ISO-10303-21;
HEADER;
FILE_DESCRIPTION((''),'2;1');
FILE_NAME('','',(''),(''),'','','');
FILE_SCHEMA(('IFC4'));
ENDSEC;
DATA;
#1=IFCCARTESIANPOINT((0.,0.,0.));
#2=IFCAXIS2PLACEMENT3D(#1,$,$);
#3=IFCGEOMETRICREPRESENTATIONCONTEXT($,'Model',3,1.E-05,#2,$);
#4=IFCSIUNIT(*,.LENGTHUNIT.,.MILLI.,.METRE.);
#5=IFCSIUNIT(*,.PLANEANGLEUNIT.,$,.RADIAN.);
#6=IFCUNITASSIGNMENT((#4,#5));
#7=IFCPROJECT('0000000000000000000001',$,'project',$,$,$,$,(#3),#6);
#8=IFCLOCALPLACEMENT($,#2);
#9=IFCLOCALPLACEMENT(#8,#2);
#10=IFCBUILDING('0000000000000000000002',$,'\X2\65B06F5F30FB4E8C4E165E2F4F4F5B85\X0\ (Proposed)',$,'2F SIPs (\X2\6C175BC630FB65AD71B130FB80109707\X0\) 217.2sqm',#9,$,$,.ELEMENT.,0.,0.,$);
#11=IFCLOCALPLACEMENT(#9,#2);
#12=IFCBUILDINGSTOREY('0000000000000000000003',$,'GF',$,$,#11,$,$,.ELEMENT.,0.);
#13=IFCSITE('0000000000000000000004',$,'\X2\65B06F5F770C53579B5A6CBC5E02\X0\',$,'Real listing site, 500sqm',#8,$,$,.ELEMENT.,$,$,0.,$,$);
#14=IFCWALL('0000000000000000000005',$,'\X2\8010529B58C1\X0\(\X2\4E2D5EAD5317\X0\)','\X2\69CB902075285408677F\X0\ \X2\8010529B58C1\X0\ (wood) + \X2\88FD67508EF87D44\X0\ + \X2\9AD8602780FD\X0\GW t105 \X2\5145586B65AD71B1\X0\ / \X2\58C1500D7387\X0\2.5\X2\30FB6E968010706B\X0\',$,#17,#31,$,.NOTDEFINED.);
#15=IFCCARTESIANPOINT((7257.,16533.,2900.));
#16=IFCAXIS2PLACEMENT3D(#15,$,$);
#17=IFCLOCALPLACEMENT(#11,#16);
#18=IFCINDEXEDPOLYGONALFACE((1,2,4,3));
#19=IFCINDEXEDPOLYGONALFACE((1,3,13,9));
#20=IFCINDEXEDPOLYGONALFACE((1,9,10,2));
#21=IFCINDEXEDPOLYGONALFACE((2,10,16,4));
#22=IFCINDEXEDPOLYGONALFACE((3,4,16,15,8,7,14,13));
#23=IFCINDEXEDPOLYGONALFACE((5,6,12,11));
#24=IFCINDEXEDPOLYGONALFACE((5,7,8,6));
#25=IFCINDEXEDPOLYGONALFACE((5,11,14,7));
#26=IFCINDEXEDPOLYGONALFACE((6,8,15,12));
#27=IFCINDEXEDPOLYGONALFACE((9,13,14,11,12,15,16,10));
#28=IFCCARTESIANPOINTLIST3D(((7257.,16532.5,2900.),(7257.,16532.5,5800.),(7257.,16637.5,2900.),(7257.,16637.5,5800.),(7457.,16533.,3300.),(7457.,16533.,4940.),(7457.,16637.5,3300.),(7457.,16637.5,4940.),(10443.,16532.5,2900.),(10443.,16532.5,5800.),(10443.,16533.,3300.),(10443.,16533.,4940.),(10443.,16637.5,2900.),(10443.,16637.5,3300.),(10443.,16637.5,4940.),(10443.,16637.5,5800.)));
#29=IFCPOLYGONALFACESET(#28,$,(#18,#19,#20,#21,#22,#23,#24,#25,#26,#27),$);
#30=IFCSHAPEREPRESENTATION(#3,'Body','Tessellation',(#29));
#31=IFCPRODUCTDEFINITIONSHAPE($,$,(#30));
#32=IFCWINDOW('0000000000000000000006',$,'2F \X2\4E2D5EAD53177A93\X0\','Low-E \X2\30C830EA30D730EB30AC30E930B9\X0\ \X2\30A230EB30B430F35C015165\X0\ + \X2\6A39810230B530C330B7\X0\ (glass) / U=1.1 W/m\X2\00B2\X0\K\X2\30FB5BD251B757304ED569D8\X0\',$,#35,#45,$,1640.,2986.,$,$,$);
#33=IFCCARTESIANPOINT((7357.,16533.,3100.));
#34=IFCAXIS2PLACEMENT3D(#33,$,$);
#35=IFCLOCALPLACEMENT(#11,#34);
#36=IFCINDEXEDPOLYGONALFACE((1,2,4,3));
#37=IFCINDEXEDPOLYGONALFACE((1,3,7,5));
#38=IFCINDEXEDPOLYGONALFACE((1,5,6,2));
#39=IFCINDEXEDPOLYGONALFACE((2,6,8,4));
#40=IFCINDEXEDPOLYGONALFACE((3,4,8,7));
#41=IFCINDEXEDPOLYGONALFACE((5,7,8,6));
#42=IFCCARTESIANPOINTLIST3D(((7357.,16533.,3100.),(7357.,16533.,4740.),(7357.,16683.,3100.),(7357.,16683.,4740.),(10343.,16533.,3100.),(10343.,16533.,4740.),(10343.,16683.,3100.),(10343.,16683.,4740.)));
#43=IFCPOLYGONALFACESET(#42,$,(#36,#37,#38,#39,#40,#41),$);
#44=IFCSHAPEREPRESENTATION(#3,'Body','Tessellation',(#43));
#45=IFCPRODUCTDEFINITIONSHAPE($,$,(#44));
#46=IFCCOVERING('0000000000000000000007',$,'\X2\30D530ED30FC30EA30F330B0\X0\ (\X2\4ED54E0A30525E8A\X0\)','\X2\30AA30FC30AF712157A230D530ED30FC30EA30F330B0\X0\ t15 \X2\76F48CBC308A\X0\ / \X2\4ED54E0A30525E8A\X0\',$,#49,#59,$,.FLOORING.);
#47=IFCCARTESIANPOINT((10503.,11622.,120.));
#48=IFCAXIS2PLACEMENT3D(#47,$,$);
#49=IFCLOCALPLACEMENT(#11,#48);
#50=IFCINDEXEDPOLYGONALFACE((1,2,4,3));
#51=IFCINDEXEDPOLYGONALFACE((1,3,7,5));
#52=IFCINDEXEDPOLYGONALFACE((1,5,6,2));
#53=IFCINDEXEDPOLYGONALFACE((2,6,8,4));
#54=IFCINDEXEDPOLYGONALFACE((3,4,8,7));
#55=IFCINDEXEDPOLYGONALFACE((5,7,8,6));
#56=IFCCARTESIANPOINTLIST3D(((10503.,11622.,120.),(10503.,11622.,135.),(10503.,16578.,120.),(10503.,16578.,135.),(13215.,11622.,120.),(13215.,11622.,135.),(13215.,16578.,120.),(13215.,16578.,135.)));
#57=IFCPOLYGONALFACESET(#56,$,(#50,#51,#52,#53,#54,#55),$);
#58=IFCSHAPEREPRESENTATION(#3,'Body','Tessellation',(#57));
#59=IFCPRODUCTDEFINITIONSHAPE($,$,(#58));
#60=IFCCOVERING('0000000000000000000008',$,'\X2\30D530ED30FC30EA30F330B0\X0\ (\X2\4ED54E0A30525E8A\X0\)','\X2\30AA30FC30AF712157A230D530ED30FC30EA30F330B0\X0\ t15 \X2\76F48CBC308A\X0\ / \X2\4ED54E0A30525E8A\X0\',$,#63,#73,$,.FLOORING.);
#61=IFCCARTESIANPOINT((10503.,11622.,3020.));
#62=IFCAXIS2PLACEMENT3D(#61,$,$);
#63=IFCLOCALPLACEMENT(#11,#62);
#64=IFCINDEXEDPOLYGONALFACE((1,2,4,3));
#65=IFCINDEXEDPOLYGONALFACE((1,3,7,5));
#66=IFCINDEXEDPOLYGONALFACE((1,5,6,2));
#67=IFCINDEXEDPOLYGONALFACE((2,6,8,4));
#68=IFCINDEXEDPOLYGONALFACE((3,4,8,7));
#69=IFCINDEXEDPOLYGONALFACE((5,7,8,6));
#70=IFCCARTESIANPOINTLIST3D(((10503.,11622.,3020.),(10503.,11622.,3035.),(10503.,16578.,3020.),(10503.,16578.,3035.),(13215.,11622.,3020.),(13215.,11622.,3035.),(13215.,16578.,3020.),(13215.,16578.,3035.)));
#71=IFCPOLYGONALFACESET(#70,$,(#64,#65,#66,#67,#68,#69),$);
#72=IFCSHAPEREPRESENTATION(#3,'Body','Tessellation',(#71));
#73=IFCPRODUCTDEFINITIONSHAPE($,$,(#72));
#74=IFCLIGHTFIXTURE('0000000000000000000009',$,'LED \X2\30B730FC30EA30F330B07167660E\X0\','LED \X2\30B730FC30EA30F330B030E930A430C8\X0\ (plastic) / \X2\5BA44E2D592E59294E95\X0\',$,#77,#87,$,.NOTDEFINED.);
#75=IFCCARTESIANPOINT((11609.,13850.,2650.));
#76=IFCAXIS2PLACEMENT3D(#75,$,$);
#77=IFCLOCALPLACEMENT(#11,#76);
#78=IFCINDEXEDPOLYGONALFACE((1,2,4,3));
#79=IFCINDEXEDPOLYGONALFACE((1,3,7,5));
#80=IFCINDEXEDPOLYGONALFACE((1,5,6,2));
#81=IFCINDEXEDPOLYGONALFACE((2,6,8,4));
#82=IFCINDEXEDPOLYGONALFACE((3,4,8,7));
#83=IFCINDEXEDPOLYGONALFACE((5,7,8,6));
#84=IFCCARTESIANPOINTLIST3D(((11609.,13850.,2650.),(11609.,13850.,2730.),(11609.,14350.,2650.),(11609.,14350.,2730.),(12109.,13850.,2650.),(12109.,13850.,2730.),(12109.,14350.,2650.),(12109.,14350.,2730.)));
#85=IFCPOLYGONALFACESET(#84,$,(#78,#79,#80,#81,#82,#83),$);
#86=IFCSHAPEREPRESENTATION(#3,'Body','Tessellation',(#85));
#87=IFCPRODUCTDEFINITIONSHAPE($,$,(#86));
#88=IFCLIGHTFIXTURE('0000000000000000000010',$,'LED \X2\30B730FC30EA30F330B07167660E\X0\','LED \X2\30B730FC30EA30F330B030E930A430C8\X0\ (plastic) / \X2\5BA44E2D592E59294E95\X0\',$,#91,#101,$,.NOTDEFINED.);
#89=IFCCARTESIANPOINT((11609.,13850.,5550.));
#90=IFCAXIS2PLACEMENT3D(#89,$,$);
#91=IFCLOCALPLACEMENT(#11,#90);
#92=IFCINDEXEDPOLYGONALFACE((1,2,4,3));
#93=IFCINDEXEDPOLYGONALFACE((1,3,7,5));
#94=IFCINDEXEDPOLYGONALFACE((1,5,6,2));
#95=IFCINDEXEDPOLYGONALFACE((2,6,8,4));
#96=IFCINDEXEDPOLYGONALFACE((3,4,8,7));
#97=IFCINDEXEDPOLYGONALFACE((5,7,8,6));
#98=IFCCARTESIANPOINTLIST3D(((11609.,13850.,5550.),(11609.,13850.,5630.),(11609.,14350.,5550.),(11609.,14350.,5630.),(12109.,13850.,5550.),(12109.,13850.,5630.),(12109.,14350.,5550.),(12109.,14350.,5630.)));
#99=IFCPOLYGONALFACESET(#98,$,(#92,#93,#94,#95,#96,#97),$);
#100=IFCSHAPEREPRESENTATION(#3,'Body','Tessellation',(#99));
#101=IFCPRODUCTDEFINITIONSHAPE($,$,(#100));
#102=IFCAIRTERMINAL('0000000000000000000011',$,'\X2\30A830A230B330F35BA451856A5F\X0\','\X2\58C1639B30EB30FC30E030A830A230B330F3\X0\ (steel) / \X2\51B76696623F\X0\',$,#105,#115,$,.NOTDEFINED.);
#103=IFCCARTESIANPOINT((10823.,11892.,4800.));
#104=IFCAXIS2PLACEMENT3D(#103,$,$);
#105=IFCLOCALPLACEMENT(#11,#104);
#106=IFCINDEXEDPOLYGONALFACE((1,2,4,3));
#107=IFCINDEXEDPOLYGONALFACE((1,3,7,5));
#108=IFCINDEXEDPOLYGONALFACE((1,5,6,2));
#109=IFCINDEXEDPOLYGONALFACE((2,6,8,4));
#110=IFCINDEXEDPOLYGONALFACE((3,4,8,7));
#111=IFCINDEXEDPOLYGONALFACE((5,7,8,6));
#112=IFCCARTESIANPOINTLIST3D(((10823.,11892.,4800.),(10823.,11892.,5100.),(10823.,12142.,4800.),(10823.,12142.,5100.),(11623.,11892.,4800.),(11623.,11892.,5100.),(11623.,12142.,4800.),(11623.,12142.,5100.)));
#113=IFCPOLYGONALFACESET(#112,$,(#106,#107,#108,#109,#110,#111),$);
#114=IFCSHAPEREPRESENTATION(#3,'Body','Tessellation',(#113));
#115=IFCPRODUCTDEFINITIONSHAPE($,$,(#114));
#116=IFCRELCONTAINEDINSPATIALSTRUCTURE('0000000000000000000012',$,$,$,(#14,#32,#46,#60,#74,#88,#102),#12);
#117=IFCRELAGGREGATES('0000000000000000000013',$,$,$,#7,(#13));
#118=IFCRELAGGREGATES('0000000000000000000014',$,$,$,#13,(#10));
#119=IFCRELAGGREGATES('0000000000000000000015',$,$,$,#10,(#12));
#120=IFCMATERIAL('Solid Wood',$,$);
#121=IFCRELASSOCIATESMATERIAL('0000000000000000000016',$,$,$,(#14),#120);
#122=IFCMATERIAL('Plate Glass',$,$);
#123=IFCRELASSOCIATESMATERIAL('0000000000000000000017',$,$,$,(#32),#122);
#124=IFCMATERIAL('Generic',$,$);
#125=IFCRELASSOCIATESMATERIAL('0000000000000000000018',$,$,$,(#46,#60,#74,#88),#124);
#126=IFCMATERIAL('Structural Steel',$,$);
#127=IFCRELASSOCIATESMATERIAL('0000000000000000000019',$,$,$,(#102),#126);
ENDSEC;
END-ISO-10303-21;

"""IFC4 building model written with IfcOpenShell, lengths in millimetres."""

from ifc_helpers import new_model, si_unit, frame, frame_2d, origin, place, context, project, spatial, rectangle, extrude, material, element, fill, save


model = new_model("IFC4")

# Units and contexts
model_context = context("Model", 3, precision=1e-05, world=origin())
ifc_project = project(units=[si_unit("LENGTHUNIT", "METRE", prefix="MILLI"), si_unit("PLANEANGLEUNIT", "RADIAN")], contexts=[model_context])

# Site, building, storey
site_placement = place(None, origin())
site = spatial("IfcSite", under=ifc_project, at=site_placement, Name="新潟県南魚沼市", ObjectType="Real listing site, 500sqm", CompositionType="ELEMENT", RefElevation=0.0)
building_placement = place(site_placement, origin())
building = spatial("IfcBuilding", under=site, at=building_placement, Name="新潟・二世帯住宅 (Proposed)", ObjectType="2F SIPs (気密・断熱・耐震) 217.2sqm", CompositionType="ELEMENT", ElevationOfRefHeight=0.0, ElevationOfTerrain=0.0)
storey_placement = place(building_placement, origin())
storey = spatial("IfcBuildingStorey", under=building, at=storey_placement, Name="GF", CompositionType="ELEMENT", Elevation=0.0)

# Shared definitions
ifc_material_1 = material(Name="Solid Wood")

# Wall, opening, window
ifc_material_2 = material(Name="Plate Glass")
wall_1_placement = place(storey_placement, frame((7257.0, 16533.0, 2900.0)))
wall_1 = element("IfcWall", 1, at=wall_1_placement, inside=storey, material=ifc_material_1, Name="耐力壁(中庭北)", Description="構造用合板 耐力壁 (wood) + 製材軸組 + 高性能GW t105 充填断熱 / 壁倍率2.5・準耐火", PredefinedType="NOTDEFINED", context=model_context, shape_type="SweptSolid", body=[
    extrude(rectangle(XDim=3186.0, YDim=105.0, at=frame_2d((1593.0, 52.0))), frame((7257.0, 16533.0, 2900.0)), (0.0, 0.0, 1.0), 2900.0),
])
opening_1_placement = place(storey_placement, frame((7357.0, 16533.0, 3100.0)))
opening_1 = element("IfcOpeningElement", 2, at=opening_1_placement, cuts=wall_1, PredefinedType="NOTDEFINED", context=model_context, shape_type="SweptSolid", body=[
    extrude(rectangle(XDim=2986.0, YDim=150.0, at=frame_2d((1493.0, 75.0))), frame((7357.0, 16533.0, 3100.0)), (0.0, 0.0, 1.0), 1640.0),
])
window_1_placement = place(storey_placement, frame((7357.0, 16533.0, 3100.0)))
window_1 = element("IfcWindow", 3, at=window_1_placement, inside=storey, material=ifc_material_2, Name="2F 中庭北窓", Description="Low-E トリプルガラス アルゴン封入 + 樹脂サッシ (glass) / U=1.1 W/m²K・寒冷地仕様", OverallHeight=1640.0, OverallWidth=2986.0, context=model_context, shape_type="SweptSolid", body=[
    extrude(rectangle(XDim=2986.0, YDim=150.0, at=frame_2d((1493.0, 75.0))), frame((7357.0, 16533.0, 3100.0)), (0.0, 0.0, 1.0), 1640.0),
])
fill(opening_1, window_1)

# Coverings
ifc_material_3 = material(Name="Generic")
covering_1_placement = place(storey_placement, frame((10503.0, 11622.0, 120.0)))
element("IfcCovering", 4, at=covering_1_placement, inside=storey, material=ifc_material_3, Name="フローリング (仕上げ床)", Description="オーク無垢フローリング t15 直貼り / 仕上げ床", PredefinedType="FLOORING", context=model_context, shape_type="SweptSolid", body=[
    extrude(rectangle(XDim=2712.0, YDim=4956.0, at=frame_2d((1356.0, 2478.0))), frame((10503.0, 11622.0, 120.0)), (0.0, 0.0, 1.0), 15.0),
])
covering_2_placement = place(storey_placement, frame((10503.0, 11622.0, 3020.0)))
element("IfcCovering", 5, at=covering_2_placement, inside=storey, material=ifc_material_3, Name="フローリング (仕上げ床)", Description="オーク無垢フローリング t15 直貼り / 仕上げ床", PredefinedType="FLOORING", context=model_context, shape_type="SweptSolid", body=[
    extrude(rectangle(XDim=2712.0, YDim=4956.0, at=frame_2d((1356.0, 2478.0))), frame((10503.0, 11622.0, 3020.0)), (0.0, 0.0, 1.0), 15.0),
])

# Light fixtures
light_fixture_1_placement = place(storey_placement, frame((11609.0, 13850.0, 2650.0)))
element("IfcLightFixture", 6, at=light_fixture_1_placement, inside=storey, material=ifc_material_3, Name="LED シーリング照明", Description="LED シーリングライト (plastic) / 室中央天井", PredefinedType="NOTDEFINED", context=model_context, shape_type="SweptSolid", body=[
    extrude(rectangle(XDim=500.0, YDim=500.0, at=frame_2d((250.0, 250.0))), frame((11609.0, 13850.0, 2650.0)), (0.0, 0.0, 1.0), 80.0),
])
light_fixture_2_placement = place(storey_placement, frame((11609.0, 13850.0, 5550.0)))
element("IfcLightFixture", 7, at=light_fixture_2_placement, inside=storey, material=ifc_material_3, Name="LED シーリング照明", Description="LED シーリングライト (plastic) / 室中央天井", PredefinedType="NOTDEFINED", context=model_context, shape_type="SweptSolid", body=[
    extrude(rectangle(XDim=500.0, YDim=500.0, at=frame_2d((250.0, 250.0))), frame((11609.0, 13850.0, 5550.0)), (0.0, 0.0, 1.0), 80.0),
])

# Air terminal
ifc_material_4 = material(Name="Structural Steel")
air_terminal_placement = place(storey_placement, frame((10823.0, 11892.0, 4800.0)))
element("IfcAirTerminal", 8, at=air_terminal_placement, inside=storey, material=ifc_material_4, Name="エアコン室内機", Description="壁掛ルームエアコン (steel) / 冷暖房", PredefinedType="NOTDEFINED", context=model_context, shape_type="SweptSolid", body=[
    extrude(rectangle(XDim=800.0, YDim=250.0, at=frame_2d((400.0, 125.0))), frame((10823.0, 11892.0, 4800.0)), (0.0, 0.0, 1.0), 300.0),
])

save(model, "model.ifc")
